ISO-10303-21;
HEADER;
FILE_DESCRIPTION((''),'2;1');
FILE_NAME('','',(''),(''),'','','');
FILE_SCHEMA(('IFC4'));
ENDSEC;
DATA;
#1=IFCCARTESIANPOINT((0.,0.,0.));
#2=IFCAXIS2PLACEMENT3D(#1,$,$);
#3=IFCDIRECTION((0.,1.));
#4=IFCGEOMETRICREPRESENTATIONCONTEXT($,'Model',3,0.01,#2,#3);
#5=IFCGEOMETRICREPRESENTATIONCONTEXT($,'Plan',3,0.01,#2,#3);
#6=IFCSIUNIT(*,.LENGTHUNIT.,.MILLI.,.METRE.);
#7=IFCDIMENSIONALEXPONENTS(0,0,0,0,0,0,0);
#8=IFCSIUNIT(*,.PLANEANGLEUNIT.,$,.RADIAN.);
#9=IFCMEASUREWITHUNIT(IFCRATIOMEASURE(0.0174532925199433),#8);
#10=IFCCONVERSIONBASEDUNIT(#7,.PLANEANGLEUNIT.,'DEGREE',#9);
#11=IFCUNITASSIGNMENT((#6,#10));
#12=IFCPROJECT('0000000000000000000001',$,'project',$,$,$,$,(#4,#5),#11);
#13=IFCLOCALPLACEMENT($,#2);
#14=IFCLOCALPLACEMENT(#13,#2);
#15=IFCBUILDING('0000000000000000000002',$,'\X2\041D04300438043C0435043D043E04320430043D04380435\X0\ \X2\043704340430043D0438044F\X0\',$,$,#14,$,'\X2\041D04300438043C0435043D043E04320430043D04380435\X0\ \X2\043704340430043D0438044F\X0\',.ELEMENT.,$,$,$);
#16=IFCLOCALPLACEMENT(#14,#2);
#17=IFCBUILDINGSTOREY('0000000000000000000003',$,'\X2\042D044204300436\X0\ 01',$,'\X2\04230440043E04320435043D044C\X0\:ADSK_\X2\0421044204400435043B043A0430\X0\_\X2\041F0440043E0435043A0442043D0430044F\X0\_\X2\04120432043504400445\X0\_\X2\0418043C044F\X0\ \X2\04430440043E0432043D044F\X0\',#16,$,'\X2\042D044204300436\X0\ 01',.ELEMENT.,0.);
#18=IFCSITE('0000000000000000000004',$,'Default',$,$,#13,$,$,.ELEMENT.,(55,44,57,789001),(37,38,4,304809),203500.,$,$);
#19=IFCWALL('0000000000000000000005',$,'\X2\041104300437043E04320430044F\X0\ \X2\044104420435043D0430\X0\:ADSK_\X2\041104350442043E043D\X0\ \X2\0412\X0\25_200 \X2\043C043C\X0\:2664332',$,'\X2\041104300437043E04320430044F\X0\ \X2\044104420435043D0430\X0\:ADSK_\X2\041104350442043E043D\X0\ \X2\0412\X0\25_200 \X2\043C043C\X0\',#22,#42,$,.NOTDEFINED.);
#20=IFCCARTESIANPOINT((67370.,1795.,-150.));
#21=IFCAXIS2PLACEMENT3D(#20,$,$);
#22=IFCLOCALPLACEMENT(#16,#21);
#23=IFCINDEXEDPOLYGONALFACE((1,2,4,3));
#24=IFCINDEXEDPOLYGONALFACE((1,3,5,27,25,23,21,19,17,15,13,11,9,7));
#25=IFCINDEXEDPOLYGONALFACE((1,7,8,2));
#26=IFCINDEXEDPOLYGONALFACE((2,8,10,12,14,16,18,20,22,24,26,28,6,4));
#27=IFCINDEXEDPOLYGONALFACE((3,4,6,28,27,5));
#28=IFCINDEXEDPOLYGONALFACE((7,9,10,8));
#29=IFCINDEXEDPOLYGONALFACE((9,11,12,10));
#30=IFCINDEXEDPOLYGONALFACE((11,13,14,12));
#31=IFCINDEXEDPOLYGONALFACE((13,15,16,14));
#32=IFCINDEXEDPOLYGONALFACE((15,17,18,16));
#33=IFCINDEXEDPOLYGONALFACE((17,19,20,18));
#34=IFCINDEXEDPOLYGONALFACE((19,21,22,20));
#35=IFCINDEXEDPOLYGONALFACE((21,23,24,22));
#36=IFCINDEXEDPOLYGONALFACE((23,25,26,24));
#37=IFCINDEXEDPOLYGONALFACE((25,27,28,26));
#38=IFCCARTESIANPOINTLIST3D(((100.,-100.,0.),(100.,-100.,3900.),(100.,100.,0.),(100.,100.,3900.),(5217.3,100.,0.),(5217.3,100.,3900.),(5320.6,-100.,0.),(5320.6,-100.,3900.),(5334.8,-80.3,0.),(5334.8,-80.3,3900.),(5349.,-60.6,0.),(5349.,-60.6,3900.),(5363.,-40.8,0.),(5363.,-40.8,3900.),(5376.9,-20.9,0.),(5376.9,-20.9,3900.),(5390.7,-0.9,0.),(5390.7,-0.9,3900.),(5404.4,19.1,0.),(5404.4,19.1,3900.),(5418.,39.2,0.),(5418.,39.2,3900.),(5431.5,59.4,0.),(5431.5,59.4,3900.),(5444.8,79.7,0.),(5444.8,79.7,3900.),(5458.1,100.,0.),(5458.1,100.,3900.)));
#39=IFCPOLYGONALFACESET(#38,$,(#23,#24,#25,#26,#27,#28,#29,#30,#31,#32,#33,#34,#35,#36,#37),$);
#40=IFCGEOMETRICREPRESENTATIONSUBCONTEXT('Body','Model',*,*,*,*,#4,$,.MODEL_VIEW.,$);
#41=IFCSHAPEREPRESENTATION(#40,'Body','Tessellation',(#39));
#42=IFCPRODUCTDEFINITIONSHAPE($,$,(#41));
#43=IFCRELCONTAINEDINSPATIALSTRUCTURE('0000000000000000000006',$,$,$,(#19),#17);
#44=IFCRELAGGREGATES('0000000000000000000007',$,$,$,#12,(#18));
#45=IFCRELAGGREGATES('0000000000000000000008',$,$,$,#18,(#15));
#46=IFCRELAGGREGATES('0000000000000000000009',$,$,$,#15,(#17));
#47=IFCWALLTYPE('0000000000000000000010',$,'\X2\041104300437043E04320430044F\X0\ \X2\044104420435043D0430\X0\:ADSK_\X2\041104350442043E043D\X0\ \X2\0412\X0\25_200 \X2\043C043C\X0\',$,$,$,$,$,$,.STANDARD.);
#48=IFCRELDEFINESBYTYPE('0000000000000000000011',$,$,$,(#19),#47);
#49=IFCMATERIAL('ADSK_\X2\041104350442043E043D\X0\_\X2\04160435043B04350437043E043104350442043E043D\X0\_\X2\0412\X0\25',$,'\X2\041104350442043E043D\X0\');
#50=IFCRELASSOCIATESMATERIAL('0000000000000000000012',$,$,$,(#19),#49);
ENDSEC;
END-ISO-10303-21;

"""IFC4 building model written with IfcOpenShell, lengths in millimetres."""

from ifc_helpers import new_model, entity, si_unit, converted_unit, direction, frame, origin, place, context, subcontext, project, spatial, indexed_curve, outline, extrude, material, type_object, element, save


model = new_model("IFC4")

# Units and contexts
model_context = context("Model", 3, precision=0.01, world=origin(), true_north=direction((0.0, 1.0)))
plan_context = context("Plan", 3, precision=0.01, world=origin(), true_north=direction((0.0, 1.0)))
body_context = subcontext(model_context, "Body", "Model", "MODEL_VIEW")
ifc_project = project(units=[si_unit("LENGTHUNIT", "METRE", prefix="MILLI"), converted_unit("PLANEANGLEUNIT", "DEGREE", entity("IfcRatioMeasure", 0.0174532925199433), si_unit("PLANEANGLEUNIT", "RADIAN"), dimensions=[0, 0, 0, 0, 0, 0, 0])], contexts=[model_context, plan_context])

# Site, building, storey
site_placement = place(None, origin())
site = spatial("IfcSite", under=ifc_project, at=site_placement, Name="Default", CompositionType="ELEMENT", RefLatitude=(55, 44, 57, 789001), RefLongitude=(37, 38, 4, 304809), RefElevation=203500.0)
building_placement = place(site_placement, origin())
building = spatial("IfcBuilding", under=site, at=building_placement, Name="Наименование здания", LongName="Наименование здания", CompositionType="ELEMENT")
storey_placement = place(building_placement, origin())
storey = spatial("IfcBuildingStorey", under=building, at=storey_placement, Name="Этаж 01", ObjectType="Уровень:ADSK_Стрелка_Проектная_Вверх_Имя уровня", LongName="Этаж 01", CompositionType="ELEMENT", Elevation=0.0)

# Wall
ifc_material = material(Name="ADSK_Бетон_Железобетон_В25", Category="Бетон")
wall_type_1 = type_object("IfcWallType", Name="Базовая стена:ADSK_Бетон В25_200 мм", PredefinedType="STANDARD")
wall_1_placement = place(storey_placement, frame((67370.0, 1795.0, -150.0)))
element("IfcWall", 1, at=wall_1_placement, inside=storey, type_object=wall_type_1, material=ifc_material, Name="Базовая стена:ADSK_Бетон В25_200 мм:2664332", ObjectType="Базовая стена:ADSK_Бетон В25_200 мм", PredefinedType="NOTDEFINED", context=body_context, shape_type="SweptSolid", body=[
    extrude(outline(indexed_curve([(5320.6, -100.0), (5334.8, -80.3), (5349.0, -60.6), (5363.0, -40.8), (5376.9, -20.9), (5390.7, -0.9), (5404.4, 19.1), (5418.0, 39.2), (5431.5, 59.4), (5444.8, 79.7), (5458.1, 100.0), (5217.3, 100.0), (100.0, 100.0), (100.0, -100.0), (5320.6, -100.0)], self_intersect=False)), origin(), (0.0, 0.0, 1.0), 3900.0),
])

save(model, "model.ifc")
